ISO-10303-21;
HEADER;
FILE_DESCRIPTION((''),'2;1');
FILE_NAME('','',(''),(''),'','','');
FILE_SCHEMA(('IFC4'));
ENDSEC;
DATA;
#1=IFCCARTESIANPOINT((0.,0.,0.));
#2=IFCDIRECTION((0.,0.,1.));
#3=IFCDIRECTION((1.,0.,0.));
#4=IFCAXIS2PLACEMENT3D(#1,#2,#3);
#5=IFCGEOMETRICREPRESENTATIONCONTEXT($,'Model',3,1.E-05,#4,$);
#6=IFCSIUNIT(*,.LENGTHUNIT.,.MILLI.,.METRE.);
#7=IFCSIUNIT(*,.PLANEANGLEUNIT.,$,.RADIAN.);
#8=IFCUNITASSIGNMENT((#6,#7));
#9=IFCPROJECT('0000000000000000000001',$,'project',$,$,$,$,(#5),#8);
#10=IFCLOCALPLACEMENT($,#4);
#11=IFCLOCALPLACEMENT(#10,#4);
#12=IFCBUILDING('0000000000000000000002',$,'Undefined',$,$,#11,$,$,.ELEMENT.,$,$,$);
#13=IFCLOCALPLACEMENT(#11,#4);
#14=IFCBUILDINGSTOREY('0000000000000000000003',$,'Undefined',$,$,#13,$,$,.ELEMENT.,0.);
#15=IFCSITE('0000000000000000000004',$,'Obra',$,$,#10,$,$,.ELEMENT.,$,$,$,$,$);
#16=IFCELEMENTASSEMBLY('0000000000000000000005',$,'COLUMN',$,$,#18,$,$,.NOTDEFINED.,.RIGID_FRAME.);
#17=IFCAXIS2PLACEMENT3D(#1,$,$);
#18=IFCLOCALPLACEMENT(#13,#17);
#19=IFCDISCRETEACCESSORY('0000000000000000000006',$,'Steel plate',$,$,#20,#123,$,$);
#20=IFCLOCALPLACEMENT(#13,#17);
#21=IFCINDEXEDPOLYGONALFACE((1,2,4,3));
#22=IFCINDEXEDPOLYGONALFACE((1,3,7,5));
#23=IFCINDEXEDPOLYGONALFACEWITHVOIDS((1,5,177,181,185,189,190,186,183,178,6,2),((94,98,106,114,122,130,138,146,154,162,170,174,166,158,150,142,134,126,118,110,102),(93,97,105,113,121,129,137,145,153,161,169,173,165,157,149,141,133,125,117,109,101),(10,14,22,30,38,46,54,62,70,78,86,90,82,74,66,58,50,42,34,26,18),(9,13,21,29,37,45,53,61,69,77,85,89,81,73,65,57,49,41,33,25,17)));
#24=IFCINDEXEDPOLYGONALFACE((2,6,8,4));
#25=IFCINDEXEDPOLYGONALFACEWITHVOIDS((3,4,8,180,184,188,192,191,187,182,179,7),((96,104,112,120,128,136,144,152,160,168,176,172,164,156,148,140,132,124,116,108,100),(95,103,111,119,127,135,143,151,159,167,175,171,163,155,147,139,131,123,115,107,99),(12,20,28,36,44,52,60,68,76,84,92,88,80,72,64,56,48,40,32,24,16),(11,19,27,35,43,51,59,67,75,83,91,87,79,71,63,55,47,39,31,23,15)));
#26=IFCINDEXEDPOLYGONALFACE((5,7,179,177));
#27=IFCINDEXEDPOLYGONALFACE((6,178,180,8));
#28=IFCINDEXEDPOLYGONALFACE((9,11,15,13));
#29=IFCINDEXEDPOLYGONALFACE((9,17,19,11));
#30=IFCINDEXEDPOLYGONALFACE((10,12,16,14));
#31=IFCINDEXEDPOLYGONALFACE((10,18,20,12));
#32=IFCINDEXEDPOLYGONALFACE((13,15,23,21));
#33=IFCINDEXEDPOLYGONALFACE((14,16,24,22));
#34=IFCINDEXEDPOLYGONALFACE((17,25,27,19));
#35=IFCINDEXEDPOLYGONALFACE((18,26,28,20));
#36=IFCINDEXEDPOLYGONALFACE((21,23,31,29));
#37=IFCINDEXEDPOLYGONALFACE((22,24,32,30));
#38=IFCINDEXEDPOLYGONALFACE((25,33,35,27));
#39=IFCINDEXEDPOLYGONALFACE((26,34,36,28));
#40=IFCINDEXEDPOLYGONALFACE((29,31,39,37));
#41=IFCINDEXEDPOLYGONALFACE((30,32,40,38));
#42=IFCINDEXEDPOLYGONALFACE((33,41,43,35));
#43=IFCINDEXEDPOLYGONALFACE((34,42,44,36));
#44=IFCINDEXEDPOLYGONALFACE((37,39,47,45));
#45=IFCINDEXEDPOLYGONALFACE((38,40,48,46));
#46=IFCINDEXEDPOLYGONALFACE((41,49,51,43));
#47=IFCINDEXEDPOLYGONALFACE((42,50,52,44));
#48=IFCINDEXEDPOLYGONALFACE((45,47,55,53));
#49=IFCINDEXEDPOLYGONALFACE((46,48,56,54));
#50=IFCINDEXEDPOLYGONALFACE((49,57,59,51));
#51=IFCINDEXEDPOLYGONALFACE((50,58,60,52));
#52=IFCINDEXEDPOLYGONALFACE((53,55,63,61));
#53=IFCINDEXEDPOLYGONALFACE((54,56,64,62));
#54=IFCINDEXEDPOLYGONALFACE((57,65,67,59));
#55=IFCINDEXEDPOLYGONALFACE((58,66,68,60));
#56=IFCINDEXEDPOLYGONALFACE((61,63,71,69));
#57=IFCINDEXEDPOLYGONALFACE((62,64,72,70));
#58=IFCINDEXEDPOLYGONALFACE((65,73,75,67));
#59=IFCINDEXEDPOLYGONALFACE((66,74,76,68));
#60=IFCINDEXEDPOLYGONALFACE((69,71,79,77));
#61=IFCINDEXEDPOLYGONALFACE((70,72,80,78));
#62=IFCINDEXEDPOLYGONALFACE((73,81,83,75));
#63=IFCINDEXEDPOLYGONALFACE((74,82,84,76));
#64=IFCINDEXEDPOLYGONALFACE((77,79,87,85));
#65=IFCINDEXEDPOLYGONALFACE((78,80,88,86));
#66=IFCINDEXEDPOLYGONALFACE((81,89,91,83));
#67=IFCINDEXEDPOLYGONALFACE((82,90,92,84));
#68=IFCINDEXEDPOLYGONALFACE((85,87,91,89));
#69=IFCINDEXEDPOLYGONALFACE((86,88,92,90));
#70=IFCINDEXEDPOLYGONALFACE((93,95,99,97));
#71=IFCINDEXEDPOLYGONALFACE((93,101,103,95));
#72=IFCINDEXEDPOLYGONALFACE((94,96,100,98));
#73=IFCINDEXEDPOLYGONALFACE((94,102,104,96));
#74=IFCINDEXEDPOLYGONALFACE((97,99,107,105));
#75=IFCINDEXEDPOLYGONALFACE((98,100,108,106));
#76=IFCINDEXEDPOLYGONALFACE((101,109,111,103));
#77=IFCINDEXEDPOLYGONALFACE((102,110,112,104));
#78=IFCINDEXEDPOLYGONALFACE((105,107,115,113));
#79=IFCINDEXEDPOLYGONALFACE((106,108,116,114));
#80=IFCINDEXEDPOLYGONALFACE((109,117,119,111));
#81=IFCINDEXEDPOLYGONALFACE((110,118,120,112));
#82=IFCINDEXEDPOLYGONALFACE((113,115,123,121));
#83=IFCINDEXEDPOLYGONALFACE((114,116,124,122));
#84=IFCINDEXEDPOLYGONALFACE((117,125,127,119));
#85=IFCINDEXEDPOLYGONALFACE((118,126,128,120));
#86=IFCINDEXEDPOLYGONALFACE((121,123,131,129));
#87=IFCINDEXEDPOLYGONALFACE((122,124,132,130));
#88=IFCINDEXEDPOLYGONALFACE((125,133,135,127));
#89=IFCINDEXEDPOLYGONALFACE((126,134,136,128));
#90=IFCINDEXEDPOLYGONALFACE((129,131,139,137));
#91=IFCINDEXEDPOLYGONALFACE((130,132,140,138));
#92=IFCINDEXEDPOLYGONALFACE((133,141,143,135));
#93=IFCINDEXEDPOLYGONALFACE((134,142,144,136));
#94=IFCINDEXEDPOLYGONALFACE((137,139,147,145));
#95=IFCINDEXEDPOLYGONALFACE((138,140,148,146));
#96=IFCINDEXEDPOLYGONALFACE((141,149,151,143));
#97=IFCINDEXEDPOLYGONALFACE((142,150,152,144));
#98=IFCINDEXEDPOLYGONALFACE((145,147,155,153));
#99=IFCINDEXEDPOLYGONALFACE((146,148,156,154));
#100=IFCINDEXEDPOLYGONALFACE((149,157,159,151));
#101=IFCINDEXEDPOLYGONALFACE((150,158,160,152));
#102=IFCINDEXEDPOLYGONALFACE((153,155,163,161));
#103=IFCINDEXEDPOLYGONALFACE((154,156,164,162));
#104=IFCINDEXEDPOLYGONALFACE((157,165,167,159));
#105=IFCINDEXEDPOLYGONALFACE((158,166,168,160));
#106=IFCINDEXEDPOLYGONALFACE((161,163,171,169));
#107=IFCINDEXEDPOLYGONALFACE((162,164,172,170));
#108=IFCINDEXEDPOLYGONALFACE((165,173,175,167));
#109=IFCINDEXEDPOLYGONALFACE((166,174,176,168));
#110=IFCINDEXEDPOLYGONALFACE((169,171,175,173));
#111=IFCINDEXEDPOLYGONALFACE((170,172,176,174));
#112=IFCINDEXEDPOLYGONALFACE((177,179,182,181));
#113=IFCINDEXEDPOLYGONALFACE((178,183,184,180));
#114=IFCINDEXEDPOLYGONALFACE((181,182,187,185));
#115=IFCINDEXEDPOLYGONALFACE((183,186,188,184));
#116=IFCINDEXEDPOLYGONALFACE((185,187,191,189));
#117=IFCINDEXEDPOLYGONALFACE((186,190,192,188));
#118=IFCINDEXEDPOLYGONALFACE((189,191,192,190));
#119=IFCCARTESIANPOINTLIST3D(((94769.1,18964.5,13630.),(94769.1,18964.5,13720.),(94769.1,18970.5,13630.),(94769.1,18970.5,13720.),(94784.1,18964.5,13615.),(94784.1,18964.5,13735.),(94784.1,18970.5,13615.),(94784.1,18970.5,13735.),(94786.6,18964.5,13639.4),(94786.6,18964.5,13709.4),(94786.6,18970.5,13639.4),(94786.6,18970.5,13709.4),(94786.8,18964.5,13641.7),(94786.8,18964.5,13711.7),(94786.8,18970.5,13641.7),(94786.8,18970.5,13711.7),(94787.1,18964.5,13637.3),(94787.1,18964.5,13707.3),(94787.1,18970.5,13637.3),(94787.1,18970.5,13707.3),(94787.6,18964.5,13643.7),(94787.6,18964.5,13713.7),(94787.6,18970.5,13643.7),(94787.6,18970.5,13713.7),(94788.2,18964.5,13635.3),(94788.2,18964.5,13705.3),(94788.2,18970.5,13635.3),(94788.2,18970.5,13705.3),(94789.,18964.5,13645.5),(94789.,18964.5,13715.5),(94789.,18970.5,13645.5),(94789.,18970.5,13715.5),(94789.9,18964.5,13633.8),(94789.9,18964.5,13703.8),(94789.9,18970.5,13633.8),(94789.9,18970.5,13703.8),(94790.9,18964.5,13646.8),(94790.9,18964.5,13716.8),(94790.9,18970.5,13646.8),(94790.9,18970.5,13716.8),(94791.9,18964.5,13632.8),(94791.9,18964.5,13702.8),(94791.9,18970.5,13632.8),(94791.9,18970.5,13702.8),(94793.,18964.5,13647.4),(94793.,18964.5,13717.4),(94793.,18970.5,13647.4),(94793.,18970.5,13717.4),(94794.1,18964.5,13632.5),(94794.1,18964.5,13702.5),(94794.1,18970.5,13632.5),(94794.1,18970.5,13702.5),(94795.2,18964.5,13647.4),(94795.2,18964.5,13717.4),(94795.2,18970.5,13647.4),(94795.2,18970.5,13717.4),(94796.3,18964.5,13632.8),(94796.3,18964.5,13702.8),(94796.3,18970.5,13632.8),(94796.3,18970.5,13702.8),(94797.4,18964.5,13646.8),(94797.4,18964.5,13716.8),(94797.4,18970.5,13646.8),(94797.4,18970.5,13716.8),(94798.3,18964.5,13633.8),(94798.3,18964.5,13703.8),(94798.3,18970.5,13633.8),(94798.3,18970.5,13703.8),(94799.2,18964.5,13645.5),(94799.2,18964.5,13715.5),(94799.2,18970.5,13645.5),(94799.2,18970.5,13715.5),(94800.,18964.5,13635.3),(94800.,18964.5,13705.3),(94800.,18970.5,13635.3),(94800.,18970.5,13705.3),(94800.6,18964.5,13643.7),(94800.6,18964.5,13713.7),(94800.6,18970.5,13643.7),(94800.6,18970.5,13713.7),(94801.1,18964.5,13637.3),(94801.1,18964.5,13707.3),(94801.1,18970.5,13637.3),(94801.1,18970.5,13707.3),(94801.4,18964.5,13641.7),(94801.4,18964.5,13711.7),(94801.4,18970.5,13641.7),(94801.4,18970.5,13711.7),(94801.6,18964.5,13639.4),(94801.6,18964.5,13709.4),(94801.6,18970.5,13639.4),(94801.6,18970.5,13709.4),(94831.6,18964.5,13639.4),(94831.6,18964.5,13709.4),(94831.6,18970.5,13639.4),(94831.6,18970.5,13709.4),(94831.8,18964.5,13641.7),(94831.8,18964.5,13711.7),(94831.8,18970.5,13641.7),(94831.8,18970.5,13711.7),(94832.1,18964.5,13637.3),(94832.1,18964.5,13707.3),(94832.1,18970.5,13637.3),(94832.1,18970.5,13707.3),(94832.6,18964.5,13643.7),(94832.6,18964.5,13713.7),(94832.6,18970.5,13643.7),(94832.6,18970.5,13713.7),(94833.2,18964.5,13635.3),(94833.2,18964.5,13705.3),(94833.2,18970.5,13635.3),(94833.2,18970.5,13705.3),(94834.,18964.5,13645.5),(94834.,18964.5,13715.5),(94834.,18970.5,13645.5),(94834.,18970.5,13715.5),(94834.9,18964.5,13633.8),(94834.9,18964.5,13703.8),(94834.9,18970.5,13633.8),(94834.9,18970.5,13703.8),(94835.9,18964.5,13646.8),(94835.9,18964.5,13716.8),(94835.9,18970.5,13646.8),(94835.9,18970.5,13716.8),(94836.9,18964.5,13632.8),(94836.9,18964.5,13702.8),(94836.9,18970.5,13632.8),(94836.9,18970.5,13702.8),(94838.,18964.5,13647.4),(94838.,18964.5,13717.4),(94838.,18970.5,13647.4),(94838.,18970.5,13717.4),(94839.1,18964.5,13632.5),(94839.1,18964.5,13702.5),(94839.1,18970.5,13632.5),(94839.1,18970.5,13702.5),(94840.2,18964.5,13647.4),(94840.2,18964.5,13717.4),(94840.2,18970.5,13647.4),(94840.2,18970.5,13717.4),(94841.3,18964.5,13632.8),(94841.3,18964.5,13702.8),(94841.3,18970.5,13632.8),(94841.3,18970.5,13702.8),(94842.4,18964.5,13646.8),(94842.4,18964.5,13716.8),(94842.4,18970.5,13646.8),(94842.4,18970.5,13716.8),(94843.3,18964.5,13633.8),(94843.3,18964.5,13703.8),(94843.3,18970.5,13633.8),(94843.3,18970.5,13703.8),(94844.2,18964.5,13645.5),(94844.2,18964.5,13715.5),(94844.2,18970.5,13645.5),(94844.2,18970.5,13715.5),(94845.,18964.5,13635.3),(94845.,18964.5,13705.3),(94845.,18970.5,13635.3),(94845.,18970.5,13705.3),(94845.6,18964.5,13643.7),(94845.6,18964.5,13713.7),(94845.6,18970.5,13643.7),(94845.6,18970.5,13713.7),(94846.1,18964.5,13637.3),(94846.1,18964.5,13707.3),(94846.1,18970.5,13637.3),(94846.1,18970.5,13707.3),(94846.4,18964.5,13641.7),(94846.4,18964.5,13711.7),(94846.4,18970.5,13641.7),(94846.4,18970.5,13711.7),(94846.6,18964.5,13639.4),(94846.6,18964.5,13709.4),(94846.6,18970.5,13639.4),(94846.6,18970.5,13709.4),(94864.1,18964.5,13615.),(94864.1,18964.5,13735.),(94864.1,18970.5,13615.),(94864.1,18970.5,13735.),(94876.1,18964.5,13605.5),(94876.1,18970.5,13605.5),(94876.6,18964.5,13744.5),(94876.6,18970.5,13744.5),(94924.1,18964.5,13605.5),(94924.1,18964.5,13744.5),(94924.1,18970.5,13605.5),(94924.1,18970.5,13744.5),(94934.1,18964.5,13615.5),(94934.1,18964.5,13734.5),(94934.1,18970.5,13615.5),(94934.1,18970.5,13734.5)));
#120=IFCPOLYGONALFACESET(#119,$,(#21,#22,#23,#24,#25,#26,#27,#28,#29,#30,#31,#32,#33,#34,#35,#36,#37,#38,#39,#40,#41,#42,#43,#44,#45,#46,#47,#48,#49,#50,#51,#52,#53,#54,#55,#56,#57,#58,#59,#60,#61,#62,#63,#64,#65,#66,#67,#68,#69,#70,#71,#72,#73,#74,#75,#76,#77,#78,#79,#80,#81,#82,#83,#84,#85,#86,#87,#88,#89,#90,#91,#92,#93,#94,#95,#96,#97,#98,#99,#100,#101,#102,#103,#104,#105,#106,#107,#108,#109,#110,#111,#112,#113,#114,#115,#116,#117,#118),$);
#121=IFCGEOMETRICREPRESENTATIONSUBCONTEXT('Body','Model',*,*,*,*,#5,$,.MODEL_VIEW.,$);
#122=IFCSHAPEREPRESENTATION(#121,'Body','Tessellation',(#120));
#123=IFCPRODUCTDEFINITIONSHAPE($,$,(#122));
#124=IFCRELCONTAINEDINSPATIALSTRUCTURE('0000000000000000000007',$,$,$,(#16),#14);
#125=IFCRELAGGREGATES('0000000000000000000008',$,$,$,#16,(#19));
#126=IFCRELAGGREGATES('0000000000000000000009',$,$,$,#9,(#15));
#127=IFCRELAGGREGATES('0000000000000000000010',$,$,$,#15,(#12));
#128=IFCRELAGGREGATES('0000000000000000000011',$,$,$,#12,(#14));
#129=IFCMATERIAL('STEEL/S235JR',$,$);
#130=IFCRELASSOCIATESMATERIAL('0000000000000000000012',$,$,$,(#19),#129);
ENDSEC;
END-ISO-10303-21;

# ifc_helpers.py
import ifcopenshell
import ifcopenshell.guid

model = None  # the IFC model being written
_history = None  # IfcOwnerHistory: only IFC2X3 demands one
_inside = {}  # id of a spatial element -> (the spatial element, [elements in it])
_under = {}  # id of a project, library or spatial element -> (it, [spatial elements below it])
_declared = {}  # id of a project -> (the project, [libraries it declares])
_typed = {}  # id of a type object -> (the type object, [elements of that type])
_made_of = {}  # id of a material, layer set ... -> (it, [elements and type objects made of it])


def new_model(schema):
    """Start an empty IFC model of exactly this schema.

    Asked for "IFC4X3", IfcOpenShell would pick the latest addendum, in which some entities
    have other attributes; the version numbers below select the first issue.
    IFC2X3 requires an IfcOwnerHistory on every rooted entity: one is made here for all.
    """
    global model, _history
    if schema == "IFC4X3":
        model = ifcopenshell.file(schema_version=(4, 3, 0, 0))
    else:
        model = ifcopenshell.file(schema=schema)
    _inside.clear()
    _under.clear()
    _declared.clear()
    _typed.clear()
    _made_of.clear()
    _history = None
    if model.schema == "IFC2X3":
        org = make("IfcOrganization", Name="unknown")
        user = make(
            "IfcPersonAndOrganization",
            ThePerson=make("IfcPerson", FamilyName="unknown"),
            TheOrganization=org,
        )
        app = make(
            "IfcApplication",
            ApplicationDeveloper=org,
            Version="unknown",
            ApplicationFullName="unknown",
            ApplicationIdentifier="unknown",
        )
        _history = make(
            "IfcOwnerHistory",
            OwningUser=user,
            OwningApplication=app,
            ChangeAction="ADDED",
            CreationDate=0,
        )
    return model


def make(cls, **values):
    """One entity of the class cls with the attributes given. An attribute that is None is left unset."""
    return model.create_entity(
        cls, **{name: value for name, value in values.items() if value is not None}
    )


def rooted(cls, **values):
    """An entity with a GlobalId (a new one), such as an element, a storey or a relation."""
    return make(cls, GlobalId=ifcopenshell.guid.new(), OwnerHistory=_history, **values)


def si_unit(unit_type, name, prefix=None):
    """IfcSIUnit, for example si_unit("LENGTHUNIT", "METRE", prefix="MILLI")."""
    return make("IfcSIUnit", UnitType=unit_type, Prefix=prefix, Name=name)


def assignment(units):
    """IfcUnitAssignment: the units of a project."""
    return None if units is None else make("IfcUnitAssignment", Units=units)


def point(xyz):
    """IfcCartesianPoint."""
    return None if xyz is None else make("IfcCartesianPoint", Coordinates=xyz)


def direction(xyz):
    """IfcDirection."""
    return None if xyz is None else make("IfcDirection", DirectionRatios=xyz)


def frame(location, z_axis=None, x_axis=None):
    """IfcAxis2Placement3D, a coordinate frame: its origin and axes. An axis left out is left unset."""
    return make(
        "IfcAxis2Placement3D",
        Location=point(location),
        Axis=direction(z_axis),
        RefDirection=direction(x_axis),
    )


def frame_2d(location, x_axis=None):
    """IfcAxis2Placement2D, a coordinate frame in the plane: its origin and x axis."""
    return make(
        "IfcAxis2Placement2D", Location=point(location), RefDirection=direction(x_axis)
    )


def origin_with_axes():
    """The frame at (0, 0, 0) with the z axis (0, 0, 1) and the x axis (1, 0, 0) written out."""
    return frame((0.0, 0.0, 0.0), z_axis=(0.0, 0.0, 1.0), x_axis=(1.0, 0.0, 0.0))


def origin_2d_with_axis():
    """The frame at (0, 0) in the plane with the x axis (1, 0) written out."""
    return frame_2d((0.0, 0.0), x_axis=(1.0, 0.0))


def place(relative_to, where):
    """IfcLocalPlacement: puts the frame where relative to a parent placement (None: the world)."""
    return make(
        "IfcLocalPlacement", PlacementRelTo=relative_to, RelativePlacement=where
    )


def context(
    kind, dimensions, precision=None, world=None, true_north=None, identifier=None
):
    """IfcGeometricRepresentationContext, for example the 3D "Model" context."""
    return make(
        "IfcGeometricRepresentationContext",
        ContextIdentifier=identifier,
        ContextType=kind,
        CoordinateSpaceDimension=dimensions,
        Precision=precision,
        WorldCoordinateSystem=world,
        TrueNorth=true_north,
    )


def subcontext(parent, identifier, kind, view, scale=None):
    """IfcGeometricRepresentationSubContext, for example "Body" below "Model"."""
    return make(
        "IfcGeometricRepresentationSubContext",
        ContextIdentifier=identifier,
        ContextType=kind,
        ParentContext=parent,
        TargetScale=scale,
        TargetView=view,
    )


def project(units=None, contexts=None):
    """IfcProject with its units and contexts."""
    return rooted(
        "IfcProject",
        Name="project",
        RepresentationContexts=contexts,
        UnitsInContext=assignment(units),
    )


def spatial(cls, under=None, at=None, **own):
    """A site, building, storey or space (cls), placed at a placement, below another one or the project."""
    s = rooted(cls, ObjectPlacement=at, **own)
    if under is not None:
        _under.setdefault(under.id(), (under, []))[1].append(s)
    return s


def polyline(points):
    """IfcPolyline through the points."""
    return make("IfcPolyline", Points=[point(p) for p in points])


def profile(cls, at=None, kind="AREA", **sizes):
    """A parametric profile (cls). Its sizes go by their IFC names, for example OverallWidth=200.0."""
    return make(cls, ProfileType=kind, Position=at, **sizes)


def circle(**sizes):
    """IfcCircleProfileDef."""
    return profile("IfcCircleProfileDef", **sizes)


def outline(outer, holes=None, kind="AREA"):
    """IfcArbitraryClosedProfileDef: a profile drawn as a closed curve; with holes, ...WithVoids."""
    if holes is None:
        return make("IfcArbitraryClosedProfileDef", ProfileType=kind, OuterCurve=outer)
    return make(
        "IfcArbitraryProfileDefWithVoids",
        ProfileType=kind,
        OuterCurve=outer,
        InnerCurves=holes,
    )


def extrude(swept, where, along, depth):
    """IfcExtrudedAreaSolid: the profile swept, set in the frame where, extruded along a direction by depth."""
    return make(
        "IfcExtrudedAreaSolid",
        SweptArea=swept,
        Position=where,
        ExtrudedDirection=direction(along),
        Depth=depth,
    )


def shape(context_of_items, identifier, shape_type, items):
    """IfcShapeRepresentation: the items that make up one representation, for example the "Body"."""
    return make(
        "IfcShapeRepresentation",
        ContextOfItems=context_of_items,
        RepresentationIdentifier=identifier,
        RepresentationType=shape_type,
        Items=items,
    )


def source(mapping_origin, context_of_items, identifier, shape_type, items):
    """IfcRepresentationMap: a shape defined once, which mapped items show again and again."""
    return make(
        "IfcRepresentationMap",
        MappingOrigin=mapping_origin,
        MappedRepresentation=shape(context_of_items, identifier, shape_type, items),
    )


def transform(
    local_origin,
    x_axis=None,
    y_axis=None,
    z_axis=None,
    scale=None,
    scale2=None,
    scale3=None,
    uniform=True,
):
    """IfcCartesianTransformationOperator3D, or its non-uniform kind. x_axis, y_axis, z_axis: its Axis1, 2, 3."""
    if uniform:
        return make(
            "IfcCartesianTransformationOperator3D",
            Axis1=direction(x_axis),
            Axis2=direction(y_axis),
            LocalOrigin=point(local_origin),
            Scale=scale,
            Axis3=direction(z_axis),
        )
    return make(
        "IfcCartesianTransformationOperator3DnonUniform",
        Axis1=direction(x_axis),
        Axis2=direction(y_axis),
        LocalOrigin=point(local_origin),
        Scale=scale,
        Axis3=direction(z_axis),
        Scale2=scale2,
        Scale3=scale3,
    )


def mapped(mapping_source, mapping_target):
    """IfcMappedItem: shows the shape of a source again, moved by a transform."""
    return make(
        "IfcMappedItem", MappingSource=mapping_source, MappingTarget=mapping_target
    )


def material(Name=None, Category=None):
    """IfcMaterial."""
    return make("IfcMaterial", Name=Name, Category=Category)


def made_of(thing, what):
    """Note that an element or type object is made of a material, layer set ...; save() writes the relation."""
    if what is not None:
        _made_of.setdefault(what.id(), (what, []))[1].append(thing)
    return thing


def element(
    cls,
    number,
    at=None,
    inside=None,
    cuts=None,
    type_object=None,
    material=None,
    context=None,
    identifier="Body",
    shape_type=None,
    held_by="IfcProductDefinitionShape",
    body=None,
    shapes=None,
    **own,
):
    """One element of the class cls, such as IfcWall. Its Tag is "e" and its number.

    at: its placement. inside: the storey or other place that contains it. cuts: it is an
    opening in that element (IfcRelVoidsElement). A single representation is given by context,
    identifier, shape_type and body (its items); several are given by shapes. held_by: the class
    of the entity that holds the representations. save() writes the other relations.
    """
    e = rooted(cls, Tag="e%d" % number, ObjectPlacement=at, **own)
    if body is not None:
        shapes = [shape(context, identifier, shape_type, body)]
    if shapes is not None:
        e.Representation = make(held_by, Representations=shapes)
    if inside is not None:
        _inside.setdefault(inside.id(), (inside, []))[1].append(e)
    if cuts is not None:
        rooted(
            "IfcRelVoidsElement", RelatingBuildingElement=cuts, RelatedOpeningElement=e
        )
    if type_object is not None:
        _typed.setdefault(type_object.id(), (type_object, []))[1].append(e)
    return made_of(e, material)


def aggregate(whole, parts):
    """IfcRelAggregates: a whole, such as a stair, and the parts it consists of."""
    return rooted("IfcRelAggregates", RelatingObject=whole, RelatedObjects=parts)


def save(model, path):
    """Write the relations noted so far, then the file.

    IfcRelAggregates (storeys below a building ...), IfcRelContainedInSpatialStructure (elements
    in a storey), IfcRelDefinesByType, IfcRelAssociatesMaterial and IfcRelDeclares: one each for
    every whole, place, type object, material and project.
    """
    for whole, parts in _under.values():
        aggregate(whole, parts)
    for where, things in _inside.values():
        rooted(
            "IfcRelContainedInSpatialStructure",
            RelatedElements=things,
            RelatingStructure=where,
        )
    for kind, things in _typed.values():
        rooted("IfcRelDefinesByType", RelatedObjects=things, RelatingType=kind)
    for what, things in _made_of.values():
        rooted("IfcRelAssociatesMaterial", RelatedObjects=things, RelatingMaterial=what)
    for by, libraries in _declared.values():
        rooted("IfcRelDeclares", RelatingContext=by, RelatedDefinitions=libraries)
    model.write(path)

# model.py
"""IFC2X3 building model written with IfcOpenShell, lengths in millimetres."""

from ifc_helpers import new_model, si_unit, frame, origin_with_axes, origin_2d_with_axis, place, context, subcontext, project, spatial, polyline, circle, outline, extrude, source, transform, mapped, material, element, aggregate, save


model = new_model("IFC2X3")

# Units and contexts
model_context = context("Model", 3, precision=1e-05, world=origin_with_axes())
body_context = subcontext(model_context, "Body", "Model", "MODEL_VIEW")
ifc_project = project(units=[si_unit("LENGTHUNIT", "METRE", prefix="MILLI"), si_unit("PLANEANGLEUNIT", "RADIAN")], contexts=[model_context])

# Site, building, storey
site_placement = place(None, origin_with_axes())
site = spatial("IfcSite", under=ifc_project, at=site_placement, Name="Obra", CompositionType="ELEMENT")
building_placement = place(site_placement, origin_with_axes())
building = spatial("IfcBuilding", under=site, at=building_placement, Name="Undefined", CompositionType="ELEMENT")
storey_placement = place(building_placement, origin_with_axes())
storey = spatial("IfcBuildingStorey", under=building, at=storey_placement, Name="Undefined", CompositionType="ELEMENT", Elevation=0.0)

# Element assembly, discrete accessory, opening
assembly_placement = place(storey_placement, origin_with_axes())
assembly = element("IfcElementAssembly", 1, at=assembly_placement, inside=storey, Name="COLUMN", AssemblyPlace="NOTDEFINED", PredefinedType="RIGID_FRAME")
ifc_material_1 = material(Name="STEEL/S235JR")
shared_shape_1 = source(origin_with_axes(), body_context, "Body", "SweptSolid", [
    extrude(circle(Radius=7.5, at=origin_2d_with_axis()), frame((0.0, 2.4, 0.0), z_axis=(0.0, 1.0, 0.0), x_axis=(1.0, 0.0, 0.0)), (0.0, 0.0, 1.0), 6.2),
])
discrete_accessory_1_placement = place(assembly_placement, frame((94934.1, 18967.5, 13615.5), z_axis=(0.0, 1.0, 0.0), x_axis=(-0.707107, 0.0, -0.707107)))
discrete_accessory_1 = element("IfcDiscreteAccessory", 2, at=discrete_accessory_1_placement, material=ifc_material_1, Name="Steel plate", context=body_context, shape_type="SweptSolid", body=[
    extrude(outline(polyline([(0.0, 0.0), (14.1, 0.0), (48.1, 33.9), (49.9, 49.1), (106.4, 105.7), (106.4, 126.9), (42.8, 190.6), (21.6, 190.6), (-35.0, 134.0), (-50.6, 131.9), (-84.1, 98.3), (-84.1, 84.1), (0.0, 0.0)])), frame((0.0, 0.0, -3.0), z_axis=(0.0, 0.0, 1.0), x_axis=(1.0, 0.0, 0.0)), (0.0, 0.0, 1.0), 6.0),
])
opening_1_placement = place(assembly_placement, frame((94816.6, 18973.0, 13710.0), z_axis=(-1.0, 0.0, 0.0), x_axis=(0.0, 0.0, -1.0)))
element("IfcOpeningElement", 3, at=opening_1_placement, cuts=discrete_accessory_1, ObjectType="Opening", context=body_context, shape_type="MappedRepresentation", body=[
    mapped(shared_shape_1, transform((0.0, 0.0, -22.5))),
    mapped(shared_shape_1, transform((70.0, 0.0, -22.5))),
    mapped(shared_shape_1, transform((0.0, 0.0, 22.5))),
    mapped(shared_shape_1, transform((70.0, 0.0, 22.5))),
])
aggregate(assembly, [discrete_accessory_1])

save(model, "model.ifc")
